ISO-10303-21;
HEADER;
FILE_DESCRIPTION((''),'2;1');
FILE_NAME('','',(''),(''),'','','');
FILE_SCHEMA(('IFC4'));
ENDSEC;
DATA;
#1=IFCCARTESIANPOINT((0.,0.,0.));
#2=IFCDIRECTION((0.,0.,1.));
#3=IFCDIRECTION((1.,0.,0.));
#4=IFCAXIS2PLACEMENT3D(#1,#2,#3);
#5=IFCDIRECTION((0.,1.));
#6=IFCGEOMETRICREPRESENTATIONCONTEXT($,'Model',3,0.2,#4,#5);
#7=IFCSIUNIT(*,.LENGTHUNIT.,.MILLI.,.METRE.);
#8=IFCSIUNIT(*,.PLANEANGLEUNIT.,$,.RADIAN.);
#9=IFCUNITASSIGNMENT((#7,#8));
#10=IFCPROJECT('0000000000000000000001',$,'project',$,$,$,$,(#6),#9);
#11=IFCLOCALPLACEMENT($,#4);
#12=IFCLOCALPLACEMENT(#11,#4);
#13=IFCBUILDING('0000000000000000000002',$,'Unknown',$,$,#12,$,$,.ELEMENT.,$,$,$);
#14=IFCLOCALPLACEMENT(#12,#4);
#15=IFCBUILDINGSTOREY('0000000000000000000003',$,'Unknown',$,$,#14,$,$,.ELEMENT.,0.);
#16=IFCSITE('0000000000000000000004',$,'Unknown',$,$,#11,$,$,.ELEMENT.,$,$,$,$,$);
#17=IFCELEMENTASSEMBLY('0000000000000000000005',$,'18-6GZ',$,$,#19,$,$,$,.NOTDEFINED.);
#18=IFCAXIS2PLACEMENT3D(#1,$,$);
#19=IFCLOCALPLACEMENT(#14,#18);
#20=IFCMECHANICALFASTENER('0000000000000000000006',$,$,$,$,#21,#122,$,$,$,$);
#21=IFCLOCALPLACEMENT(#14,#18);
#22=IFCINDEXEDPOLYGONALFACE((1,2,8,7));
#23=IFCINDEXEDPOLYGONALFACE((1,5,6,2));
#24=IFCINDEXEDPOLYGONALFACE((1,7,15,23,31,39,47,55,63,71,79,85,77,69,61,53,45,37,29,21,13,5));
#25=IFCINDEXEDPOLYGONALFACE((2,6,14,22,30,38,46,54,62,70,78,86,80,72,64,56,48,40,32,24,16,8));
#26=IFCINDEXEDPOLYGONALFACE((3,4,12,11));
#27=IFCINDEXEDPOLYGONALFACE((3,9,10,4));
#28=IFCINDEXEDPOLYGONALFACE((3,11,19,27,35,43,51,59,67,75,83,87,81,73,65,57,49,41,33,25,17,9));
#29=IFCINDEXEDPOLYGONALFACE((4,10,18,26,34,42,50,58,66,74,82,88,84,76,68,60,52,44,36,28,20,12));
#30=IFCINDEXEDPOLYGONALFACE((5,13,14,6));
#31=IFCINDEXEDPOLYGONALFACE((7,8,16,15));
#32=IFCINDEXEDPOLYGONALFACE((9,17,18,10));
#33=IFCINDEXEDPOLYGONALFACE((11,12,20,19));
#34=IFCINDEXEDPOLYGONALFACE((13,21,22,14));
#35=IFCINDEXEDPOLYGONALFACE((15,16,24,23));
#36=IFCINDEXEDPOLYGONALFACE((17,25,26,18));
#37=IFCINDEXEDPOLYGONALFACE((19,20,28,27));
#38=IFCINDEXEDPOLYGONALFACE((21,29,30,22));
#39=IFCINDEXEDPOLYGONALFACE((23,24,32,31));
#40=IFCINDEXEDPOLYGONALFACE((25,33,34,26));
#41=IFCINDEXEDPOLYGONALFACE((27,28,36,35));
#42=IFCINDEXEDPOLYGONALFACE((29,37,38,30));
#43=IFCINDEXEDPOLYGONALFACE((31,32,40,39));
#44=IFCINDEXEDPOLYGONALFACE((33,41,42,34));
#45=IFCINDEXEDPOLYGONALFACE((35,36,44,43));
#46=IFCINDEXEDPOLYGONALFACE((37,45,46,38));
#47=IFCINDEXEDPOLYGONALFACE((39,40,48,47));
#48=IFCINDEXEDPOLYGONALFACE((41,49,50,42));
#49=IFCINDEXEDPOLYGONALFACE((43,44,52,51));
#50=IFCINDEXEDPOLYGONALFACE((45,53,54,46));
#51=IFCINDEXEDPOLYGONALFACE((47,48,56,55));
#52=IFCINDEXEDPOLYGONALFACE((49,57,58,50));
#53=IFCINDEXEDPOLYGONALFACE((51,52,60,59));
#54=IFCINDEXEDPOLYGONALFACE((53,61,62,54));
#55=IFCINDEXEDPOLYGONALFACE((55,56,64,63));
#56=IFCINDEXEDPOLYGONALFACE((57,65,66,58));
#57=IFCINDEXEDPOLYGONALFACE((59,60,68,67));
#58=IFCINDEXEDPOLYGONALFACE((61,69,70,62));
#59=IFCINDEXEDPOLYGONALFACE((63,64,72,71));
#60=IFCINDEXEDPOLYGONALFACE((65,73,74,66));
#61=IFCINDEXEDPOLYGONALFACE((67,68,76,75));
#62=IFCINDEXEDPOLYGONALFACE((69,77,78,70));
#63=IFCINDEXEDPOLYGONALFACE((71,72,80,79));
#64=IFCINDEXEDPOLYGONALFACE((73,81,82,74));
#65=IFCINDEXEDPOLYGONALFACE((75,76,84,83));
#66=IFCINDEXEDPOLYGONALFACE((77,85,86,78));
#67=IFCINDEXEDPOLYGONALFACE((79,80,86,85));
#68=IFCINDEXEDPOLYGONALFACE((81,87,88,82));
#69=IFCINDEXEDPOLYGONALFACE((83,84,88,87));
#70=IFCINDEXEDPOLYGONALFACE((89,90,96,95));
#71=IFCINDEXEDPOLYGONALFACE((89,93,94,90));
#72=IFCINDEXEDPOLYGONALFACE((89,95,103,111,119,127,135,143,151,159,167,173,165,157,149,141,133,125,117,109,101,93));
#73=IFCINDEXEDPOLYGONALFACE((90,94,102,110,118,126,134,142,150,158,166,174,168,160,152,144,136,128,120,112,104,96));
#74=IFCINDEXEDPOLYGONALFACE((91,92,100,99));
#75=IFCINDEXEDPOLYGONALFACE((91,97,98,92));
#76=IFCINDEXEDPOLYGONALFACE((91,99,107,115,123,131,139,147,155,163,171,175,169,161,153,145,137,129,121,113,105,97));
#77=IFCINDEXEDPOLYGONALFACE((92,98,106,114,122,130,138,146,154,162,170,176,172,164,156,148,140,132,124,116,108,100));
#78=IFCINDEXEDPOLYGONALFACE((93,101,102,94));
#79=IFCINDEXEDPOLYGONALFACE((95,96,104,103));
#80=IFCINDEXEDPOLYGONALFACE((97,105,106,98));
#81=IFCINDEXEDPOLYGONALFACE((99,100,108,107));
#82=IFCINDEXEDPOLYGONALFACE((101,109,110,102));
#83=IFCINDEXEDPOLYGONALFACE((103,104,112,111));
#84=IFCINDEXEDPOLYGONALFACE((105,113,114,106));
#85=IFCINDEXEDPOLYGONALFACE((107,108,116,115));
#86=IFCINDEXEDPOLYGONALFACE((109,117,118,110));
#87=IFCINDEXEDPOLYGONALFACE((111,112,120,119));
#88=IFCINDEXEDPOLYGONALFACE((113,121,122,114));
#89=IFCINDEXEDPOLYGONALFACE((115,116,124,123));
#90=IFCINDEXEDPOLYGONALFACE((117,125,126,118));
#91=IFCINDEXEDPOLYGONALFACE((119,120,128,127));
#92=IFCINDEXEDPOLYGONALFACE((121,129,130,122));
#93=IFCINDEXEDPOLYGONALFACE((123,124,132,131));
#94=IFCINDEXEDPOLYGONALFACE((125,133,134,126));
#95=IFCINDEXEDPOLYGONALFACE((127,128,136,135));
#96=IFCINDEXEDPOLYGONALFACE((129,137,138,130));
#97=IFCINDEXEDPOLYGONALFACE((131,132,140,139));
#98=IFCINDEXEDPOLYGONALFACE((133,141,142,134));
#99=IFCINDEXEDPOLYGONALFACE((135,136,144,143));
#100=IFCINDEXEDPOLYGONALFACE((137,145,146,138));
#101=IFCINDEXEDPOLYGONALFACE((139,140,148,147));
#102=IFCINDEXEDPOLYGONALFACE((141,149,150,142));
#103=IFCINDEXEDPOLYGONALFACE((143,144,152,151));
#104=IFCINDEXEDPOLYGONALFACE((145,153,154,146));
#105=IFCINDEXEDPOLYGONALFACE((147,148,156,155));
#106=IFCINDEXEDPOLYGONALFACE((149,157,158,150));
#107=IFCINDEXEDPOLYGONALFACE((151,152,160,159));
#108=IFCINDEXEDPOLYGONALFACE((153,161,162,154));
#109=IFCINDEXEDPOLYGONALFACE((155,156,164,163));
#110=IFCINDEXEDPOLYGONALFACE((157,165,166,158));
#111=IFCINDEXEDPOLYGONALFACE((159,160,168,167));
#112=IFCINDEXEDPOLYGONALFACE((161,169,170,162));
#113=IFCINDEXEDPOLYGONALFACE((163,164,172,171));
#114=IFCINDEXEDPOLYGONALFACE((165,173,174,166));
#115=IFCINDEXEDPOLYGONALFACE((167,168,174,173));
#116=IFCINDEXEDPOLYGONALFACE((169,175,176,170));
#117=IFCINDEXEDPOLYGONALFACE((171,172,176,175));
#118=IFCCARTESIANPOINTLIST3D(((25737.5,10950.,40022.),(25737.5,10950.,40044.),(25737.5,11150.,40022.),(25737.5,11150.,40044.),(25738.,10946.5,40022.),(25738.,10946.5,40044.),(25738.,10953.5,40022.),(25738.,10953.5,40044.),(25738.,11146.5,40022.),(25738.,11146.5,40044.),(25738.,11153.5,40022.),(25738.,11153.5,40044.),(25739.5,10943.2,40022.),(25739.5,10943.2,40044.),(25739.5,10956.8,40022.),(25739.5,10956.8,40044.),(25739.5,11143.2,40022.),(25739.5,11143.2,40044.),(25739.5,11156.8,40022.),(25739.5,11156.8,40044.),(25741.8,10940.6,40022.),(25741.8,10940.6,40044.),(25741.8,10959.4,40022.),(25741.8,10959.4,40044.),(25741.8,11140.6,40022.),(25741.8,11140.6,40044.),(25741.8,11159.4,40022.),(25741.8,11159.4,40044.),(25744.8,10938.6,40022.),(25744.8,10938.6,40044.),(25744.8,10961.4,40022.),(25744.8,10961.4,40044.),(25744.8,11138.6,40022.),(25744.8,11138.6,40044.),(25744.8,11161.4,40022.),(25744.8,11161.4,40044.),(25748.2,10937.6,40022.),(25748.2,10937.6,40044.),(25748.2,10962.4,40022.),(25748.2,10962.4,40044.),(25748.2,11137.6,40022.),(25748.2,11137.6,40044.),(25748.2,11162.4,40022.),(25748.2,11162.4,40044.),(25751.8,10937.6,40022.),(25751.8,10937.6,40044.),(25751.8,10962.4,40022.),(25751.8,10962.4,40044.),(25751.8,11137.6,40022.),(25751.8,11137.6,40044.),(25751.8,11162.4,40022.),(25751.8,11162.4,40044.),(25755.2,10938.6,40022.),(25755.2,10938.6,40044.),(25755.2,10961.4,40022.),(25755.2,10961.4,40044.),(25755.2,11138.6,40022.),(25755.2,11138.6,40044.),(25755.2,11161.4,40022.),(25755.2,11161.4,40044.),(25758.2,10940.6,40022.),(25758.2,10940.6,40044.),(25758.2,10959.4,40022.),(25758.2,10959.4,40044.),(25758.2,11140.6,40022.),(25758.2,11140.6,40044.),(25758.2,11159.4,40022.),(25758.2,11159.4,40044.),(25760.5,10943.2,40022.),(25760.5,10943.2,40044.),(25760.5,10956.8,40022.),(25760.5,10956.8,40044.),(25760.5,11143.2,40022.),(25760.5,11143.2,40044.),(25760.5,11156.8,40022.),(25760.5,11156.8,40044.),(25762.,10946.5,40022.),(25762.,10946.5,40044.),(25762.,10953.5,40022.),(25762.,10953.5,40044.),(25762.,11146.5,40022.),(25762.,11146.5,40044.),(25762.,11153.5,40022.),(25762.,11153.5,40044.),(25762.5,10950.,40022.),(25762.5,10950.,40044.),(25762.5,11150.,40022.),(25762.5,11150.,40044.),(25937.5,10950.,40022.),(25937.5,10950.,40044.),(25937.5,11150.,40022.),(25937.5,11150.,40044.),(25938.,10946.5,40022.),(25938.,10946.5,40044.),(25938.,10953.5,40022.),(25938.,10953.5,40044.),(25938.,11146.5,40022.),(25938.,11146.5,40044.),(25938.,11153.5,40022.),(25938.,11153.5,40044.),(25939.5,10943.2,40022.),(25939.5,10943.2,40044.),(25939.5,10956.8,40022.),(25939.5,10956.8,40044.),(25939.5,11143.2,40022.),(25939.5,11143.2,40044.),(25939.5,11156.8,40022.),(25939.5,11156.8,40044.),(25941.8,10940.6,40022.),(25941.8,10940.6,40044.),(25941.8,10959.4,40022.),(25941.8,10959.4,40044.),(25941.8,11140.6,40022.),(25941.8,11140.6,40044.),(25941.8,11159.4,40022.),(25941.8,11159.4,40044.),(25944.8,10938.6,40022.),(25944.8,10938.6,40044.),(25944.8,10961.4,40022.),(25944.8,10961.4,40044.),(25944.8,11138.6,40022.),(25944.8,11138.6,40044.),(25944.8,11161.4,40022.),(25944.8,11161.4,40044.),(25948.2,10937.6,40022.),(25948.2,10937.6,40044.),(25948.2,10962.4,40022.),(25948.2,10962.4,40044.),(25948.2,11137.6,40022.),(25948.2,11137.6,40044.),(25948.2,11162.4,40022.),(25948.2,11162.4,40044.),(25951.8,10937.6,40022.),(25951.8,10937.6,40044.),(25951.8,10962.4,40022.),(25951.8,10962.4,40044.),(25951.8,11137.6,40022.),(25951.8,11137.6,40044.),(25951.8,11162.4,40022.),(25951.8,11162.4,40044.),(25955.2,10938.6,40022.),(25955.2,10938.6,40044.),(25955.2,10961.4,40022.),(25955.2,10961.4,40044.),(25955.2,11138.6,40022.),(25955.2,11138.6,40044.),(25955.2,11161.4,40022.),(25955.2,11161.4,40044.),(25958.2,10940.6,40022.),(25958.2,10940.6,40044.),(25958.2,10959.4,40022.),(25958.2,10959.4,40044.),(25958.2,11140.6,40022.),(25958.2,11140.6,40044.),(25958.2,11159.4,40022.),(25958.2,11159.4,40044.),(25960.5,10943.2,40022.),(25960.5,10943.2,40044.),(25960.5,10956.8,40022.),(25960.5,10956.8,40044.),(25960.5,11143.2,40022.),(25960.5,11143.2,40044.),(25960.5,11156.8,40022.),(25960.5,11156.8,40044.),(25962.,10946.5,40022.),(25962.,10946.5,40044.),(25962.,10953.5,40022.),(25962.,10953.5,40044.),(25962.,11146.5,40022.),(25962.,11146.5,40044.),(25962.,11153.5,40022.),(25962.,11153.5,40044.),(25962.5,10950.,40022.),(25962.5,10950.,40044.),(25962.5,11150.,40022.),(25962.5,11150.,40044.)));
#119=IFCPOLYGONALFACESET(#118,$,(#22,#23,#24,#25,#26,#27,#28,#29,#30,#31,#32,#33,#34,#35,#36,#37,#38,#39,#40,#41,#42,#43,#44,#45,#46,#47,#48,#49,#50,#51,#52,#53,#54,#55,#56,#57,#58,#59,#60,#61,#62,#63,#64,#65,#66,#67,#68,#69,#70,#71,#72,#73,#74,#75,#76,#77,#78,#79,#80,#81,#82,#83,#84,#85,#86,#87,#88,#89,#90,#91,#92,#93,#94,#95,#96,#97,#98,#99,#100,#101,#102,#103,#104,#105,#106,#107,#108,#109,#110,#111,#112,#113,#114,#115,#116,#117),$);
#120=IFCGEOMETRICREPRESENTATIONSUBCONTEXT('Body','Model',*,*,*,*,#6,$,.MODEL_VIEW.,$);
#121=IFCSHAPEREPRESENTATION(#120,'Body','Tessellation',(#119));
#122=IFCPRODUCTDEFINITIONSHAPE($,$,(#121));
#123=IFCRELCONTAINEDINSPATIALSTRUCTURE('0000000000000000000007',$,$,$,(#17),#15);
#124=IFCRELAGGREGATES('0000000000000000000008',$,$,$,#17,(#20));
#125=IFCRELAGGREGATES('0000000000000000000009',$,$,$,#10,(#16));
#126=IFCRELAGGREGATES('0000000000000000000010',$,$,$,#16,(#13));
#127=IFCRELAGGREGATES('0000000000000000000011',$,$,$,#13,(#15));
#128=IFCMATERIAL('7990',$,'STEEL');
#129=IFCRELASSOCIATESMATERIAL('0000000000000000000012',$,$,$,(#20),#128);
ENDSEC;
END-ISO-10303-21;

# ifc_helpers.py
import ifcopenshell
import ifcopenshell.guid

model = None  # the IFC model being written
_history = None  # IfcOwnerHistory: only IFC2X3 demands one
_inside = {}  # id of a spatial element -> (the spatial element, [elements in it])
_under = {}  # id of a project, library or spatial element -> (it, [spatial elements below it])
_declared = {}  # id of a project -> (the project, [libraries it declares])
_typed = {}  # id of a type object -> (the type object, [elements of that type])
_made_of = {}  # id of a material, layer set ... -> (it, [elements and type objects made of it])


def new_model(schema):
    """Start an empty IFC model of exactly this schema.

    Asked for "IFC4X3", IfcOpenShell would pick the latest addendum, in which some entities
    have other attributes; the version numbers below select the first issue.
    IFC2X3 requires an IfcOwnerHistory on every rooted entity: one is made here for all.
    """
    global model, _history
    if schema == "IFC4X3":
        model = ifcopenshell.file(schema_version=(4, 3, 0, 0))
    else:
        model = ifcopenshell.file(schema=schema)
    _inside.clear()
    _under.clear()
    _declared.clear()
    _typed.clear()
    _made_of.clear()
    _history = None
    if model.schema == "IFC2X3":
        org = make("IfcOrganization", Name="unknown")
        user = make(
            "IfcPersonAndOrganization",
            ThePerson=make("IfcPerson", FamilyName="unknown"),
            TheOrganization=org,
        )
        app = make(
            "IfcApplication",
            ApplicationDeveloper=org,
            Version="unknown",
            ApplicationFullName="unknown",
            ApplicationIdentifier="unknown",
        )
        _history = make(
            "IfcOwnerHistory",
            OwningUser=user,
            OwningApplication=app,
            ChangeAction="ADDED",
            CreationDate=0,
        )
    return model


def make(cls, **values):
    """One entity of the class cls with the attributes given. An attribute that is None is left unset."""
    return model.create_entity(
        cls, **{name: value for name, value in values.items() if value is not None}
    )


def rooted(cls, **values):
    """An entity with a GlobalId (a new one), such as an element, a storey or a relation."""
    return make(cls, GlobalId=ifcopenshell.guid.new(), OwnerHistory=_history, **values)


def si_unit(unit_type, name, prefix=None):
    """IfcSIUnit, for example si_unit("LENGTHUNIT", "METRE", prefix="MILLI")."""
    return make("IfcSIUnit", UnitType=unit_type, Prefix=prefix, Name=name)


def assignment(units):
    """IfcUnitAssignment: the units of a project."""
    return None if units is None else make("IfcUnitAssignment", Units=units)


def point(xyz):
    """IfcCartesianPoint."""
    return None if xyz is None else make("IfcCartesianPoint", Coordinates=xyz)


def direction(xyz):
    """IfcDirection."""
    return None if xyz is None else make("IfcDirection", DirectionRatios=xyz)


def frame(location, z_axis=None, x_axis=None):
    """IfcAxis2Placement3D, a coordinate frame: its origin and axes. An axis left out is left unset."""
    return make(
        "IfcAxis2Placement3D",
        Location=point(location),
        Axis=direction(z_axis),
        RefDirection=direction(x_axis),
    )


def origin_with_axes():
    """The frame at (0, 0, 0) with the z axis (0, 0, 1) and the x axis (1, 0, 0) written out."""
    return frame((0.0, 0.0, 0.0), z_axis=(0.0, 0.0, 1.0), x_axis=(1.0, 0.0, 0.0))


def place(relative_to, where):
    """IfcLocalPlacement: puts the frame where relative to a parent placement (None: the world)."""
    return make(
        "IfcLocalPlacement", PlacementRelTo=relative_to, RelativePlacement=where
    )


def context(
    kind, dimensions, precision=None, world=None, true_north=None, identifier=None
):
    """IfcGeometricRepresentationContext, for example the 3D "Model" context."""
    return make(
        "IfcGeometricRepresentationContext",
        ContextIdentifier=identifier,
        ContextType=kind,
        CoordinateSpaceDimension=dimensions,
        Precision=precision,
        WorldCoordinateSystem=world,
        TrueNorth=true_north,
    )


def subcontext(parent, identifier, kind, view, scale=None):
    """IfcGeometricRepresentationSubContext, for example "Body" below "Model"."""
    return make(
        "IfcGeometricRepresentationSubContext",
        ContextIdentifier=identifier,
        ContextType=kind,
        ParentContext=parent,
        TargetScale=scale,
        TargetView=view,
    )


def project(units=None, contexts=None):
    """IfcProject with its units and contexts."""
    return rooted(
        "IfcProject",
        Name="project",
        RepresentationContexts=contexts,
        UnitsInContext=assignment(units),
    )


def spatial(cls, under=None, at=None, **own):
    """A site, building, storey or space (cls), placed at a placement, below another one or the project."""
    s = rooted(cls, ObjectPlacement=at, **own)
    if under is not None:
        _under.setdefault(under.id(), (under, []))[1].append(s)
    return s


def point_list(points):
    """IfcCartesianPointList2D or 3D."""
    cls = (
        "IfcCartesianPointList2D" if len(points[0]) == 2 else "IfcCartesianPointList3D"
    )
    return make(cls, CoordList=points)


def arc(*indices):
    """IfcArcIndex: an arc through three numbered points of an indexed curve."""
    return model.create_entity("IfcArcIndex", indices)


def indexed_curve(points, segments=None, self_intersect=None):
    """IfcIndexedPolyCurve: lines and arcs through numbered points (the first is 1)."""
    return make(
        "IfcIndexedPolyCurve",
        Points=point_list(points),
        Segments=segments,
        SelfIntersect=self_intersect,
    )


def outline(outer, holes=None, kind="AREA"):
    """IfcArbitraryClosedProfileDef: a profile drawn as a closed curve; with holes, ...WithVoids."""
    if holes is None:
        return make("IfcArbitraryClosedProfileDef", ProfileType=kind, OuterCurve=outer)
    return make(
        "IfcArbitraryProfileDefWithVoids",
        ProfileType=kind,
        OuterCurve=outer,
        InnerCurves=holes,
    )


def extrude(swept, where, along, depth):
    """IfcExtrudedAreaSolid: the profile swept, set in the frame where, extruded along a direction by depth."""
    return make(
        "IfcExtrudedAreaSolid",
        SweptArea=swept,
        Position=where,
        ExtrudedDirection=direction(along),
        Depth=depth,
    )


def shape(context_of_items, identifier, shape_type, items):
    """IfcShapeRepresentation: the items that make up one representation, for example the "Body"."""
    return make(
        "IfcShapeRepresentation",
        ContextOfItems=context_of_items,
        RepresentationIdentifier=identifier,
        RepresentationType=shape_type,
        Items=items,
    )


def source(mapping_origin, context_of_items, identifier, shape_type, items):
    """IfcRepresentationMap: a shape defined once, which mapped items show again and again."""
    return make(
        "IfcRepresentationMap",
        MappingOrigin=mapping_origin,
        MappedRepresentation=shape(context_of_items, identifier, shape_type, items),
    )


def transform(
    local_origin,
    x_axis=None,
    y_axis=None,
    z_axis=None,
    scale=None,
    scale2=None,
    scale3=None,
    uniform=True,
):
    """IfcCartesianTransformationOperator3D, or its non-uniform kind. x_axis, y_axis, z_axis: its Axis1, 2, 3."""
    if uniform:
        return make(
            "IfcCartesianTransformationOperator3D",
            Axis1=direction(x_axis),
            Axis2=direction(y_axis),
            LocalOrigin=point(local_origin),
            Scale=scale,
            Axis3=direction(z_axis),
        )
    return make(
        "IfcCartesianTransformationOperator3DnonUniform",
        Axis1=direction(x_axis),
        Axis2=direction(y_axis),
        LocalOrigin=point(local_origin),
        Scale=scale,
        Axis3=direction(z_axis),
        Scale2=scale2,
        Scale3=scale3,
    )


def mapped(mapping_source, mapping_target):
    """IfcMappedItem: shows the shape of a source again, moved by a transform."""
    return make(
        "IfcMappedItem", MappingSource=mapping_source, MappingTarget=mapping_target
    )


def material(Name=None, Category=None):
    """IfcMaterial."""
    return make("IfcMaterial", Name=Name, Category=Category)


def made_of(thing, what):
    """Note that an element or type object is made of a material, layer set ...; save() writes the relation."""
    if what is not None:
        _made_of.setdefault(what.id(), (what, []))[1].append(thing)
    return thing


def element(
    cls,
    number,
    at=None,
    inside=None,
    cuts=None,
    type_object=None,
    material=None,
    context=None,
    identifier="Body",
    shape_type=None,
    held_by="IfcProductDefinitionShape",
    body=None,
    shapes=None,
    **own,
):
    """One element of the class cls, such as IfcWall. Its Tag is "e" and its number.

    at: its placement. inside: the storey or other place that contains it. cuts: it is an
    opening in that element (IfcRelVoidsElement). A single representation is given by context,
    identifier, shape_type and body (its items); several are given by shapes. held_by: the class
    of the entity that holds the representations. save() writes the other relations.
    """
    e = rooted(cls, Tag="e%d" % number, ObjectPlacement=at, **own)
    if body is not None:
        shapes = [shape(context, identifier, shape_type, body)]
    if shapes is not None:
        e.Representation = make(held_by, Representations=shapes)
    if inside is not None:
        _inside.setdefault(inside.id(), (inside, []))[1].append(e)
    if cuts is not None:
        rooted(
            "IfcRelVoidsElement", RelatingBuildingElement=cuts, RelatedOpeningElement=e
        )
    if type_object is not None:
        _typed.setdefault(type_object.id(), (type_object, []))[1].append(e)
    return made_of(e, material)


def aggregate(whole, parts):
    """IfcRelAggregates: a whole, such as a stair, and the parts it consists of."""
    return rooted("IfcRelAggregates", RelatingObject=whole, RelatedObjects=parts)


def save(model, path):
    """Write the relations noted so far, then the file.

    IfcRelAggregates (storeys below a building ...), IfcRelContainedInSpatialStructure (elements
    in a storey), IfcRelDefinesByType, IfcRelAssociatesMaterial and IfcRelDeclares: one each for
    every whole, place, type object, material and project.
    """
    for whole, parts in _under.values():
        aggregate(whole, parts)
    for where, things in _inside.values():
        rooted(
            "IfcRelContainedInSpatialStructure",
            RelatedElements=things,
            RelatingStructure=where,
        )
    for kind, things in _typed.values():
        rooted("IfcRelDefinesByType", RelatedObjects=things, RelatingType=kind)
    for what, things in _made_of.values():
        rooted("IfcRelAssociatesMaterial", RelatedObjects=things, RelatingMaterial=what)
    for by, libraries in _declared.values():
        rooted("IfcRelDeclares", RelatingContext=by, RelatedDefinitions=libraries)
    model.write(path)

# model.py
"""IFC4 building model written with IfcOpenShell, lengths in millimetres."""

from ifc_helpers import new_model, si_unit, direction, frame, origin_with_axes, place, context, subcontext, project, spatial, arc, indexed_curve, outline, extrude, source, transform, mapped, material, element, aggregate, save


model = new_model("IFC4")

# Units and contexts
model_context = context("Model", 3, precision=0.2, world=origin_with_axes(), true_north=direction((0.0, 1.0)))
body_context = subcontext(model_context, "Body", "Model", "MODEL_VIEW")
ifc_project = project(units=[si_unit("LENGTHUNIT", "METRE", prefix="MILLI"), si_unit("PLANEANGLEUNIT", "RADIAN")], contexts=[model_context])

# Site, building, storey
site_placement = place(None, origin_with_axes())
site = spatial("IfcSite", under=ifc_project, at=site_placement, Name="Unknown", CompositionType="ELEMENT")
building_placement = place(site_placement, origin_with_axes())
building = spatial("IfcBuilding", under=site, at=building_placement, Name="Unknown", CompositionType="ELEMENT")
storey_placement = place(building_placement, origin_with_axes())
storey = spatial("IfcBuildingStorey", under=building, at=storey_placement, Name="Unknown", CompositionType="ELEMENT", Elevation=0.0)

# Element assembly
assembly_1_placement = place(storey_placement, frame((25850.0, 11050.0, 35950.0), z_axis=(-1.0, 0.0, 0.0), x_axis=(0.0, 0.0, 1.0)))
assembly_1 = element("IfcElementAssembly", 1, at=assembly_1_placement, inside=storey, Name="18-6GZ", PredefinedType="NOTDEFINED")

# Mechanical fastener
ifc_material_1 = material(Name="7990", Category="STEEL")
placement_1 = place(assembly_1_placement, frame((4072.0, 0.0, 0.0), z_axis=(-1.0, 0.0, 0.0), x_axis=(0.0, 1.0, 0.0)))
shared_shape_1 = source(origin_with_axes(), body_context, "Body", "SweptSolid", [
    extrude(outline(indexed_curve([(12.5, 0.0), (0.0, 12.5), (-12.5, 0.0), (0.0, -12.5)], segments=[arc(1, 2, 3), arc(3, 4, 1)])), frame((0.0, 0.0, 0.0), z_axis=(0.0, 0.0, -1.0), x_axis=(0.0, 1.0, 0.0)), (0.0, 0.0, 1.0), 22.0),
])
mechanical_fastener_1 = element("IfcMechanicalFastener", 2, at=placement_1, material=ifc_material_1, context=body_context, shape_type="MappedRepresentation", body=[
    mapped(shared_shape_1, transform((-100.0, -100.0, 0.0))),
    mapped(shared_shape_1, transform((100.0, -100.0, 0.0))),
    mapped(shared_shape_1, transform((-100.0, 100.0, 0.0))),
    mapped(shared_shape_1, transform((100.0, 100.0, 0.0))),
])
aggregate(assembly_1, [mechanical_fastener_1])

save(model, "model.ifc")
